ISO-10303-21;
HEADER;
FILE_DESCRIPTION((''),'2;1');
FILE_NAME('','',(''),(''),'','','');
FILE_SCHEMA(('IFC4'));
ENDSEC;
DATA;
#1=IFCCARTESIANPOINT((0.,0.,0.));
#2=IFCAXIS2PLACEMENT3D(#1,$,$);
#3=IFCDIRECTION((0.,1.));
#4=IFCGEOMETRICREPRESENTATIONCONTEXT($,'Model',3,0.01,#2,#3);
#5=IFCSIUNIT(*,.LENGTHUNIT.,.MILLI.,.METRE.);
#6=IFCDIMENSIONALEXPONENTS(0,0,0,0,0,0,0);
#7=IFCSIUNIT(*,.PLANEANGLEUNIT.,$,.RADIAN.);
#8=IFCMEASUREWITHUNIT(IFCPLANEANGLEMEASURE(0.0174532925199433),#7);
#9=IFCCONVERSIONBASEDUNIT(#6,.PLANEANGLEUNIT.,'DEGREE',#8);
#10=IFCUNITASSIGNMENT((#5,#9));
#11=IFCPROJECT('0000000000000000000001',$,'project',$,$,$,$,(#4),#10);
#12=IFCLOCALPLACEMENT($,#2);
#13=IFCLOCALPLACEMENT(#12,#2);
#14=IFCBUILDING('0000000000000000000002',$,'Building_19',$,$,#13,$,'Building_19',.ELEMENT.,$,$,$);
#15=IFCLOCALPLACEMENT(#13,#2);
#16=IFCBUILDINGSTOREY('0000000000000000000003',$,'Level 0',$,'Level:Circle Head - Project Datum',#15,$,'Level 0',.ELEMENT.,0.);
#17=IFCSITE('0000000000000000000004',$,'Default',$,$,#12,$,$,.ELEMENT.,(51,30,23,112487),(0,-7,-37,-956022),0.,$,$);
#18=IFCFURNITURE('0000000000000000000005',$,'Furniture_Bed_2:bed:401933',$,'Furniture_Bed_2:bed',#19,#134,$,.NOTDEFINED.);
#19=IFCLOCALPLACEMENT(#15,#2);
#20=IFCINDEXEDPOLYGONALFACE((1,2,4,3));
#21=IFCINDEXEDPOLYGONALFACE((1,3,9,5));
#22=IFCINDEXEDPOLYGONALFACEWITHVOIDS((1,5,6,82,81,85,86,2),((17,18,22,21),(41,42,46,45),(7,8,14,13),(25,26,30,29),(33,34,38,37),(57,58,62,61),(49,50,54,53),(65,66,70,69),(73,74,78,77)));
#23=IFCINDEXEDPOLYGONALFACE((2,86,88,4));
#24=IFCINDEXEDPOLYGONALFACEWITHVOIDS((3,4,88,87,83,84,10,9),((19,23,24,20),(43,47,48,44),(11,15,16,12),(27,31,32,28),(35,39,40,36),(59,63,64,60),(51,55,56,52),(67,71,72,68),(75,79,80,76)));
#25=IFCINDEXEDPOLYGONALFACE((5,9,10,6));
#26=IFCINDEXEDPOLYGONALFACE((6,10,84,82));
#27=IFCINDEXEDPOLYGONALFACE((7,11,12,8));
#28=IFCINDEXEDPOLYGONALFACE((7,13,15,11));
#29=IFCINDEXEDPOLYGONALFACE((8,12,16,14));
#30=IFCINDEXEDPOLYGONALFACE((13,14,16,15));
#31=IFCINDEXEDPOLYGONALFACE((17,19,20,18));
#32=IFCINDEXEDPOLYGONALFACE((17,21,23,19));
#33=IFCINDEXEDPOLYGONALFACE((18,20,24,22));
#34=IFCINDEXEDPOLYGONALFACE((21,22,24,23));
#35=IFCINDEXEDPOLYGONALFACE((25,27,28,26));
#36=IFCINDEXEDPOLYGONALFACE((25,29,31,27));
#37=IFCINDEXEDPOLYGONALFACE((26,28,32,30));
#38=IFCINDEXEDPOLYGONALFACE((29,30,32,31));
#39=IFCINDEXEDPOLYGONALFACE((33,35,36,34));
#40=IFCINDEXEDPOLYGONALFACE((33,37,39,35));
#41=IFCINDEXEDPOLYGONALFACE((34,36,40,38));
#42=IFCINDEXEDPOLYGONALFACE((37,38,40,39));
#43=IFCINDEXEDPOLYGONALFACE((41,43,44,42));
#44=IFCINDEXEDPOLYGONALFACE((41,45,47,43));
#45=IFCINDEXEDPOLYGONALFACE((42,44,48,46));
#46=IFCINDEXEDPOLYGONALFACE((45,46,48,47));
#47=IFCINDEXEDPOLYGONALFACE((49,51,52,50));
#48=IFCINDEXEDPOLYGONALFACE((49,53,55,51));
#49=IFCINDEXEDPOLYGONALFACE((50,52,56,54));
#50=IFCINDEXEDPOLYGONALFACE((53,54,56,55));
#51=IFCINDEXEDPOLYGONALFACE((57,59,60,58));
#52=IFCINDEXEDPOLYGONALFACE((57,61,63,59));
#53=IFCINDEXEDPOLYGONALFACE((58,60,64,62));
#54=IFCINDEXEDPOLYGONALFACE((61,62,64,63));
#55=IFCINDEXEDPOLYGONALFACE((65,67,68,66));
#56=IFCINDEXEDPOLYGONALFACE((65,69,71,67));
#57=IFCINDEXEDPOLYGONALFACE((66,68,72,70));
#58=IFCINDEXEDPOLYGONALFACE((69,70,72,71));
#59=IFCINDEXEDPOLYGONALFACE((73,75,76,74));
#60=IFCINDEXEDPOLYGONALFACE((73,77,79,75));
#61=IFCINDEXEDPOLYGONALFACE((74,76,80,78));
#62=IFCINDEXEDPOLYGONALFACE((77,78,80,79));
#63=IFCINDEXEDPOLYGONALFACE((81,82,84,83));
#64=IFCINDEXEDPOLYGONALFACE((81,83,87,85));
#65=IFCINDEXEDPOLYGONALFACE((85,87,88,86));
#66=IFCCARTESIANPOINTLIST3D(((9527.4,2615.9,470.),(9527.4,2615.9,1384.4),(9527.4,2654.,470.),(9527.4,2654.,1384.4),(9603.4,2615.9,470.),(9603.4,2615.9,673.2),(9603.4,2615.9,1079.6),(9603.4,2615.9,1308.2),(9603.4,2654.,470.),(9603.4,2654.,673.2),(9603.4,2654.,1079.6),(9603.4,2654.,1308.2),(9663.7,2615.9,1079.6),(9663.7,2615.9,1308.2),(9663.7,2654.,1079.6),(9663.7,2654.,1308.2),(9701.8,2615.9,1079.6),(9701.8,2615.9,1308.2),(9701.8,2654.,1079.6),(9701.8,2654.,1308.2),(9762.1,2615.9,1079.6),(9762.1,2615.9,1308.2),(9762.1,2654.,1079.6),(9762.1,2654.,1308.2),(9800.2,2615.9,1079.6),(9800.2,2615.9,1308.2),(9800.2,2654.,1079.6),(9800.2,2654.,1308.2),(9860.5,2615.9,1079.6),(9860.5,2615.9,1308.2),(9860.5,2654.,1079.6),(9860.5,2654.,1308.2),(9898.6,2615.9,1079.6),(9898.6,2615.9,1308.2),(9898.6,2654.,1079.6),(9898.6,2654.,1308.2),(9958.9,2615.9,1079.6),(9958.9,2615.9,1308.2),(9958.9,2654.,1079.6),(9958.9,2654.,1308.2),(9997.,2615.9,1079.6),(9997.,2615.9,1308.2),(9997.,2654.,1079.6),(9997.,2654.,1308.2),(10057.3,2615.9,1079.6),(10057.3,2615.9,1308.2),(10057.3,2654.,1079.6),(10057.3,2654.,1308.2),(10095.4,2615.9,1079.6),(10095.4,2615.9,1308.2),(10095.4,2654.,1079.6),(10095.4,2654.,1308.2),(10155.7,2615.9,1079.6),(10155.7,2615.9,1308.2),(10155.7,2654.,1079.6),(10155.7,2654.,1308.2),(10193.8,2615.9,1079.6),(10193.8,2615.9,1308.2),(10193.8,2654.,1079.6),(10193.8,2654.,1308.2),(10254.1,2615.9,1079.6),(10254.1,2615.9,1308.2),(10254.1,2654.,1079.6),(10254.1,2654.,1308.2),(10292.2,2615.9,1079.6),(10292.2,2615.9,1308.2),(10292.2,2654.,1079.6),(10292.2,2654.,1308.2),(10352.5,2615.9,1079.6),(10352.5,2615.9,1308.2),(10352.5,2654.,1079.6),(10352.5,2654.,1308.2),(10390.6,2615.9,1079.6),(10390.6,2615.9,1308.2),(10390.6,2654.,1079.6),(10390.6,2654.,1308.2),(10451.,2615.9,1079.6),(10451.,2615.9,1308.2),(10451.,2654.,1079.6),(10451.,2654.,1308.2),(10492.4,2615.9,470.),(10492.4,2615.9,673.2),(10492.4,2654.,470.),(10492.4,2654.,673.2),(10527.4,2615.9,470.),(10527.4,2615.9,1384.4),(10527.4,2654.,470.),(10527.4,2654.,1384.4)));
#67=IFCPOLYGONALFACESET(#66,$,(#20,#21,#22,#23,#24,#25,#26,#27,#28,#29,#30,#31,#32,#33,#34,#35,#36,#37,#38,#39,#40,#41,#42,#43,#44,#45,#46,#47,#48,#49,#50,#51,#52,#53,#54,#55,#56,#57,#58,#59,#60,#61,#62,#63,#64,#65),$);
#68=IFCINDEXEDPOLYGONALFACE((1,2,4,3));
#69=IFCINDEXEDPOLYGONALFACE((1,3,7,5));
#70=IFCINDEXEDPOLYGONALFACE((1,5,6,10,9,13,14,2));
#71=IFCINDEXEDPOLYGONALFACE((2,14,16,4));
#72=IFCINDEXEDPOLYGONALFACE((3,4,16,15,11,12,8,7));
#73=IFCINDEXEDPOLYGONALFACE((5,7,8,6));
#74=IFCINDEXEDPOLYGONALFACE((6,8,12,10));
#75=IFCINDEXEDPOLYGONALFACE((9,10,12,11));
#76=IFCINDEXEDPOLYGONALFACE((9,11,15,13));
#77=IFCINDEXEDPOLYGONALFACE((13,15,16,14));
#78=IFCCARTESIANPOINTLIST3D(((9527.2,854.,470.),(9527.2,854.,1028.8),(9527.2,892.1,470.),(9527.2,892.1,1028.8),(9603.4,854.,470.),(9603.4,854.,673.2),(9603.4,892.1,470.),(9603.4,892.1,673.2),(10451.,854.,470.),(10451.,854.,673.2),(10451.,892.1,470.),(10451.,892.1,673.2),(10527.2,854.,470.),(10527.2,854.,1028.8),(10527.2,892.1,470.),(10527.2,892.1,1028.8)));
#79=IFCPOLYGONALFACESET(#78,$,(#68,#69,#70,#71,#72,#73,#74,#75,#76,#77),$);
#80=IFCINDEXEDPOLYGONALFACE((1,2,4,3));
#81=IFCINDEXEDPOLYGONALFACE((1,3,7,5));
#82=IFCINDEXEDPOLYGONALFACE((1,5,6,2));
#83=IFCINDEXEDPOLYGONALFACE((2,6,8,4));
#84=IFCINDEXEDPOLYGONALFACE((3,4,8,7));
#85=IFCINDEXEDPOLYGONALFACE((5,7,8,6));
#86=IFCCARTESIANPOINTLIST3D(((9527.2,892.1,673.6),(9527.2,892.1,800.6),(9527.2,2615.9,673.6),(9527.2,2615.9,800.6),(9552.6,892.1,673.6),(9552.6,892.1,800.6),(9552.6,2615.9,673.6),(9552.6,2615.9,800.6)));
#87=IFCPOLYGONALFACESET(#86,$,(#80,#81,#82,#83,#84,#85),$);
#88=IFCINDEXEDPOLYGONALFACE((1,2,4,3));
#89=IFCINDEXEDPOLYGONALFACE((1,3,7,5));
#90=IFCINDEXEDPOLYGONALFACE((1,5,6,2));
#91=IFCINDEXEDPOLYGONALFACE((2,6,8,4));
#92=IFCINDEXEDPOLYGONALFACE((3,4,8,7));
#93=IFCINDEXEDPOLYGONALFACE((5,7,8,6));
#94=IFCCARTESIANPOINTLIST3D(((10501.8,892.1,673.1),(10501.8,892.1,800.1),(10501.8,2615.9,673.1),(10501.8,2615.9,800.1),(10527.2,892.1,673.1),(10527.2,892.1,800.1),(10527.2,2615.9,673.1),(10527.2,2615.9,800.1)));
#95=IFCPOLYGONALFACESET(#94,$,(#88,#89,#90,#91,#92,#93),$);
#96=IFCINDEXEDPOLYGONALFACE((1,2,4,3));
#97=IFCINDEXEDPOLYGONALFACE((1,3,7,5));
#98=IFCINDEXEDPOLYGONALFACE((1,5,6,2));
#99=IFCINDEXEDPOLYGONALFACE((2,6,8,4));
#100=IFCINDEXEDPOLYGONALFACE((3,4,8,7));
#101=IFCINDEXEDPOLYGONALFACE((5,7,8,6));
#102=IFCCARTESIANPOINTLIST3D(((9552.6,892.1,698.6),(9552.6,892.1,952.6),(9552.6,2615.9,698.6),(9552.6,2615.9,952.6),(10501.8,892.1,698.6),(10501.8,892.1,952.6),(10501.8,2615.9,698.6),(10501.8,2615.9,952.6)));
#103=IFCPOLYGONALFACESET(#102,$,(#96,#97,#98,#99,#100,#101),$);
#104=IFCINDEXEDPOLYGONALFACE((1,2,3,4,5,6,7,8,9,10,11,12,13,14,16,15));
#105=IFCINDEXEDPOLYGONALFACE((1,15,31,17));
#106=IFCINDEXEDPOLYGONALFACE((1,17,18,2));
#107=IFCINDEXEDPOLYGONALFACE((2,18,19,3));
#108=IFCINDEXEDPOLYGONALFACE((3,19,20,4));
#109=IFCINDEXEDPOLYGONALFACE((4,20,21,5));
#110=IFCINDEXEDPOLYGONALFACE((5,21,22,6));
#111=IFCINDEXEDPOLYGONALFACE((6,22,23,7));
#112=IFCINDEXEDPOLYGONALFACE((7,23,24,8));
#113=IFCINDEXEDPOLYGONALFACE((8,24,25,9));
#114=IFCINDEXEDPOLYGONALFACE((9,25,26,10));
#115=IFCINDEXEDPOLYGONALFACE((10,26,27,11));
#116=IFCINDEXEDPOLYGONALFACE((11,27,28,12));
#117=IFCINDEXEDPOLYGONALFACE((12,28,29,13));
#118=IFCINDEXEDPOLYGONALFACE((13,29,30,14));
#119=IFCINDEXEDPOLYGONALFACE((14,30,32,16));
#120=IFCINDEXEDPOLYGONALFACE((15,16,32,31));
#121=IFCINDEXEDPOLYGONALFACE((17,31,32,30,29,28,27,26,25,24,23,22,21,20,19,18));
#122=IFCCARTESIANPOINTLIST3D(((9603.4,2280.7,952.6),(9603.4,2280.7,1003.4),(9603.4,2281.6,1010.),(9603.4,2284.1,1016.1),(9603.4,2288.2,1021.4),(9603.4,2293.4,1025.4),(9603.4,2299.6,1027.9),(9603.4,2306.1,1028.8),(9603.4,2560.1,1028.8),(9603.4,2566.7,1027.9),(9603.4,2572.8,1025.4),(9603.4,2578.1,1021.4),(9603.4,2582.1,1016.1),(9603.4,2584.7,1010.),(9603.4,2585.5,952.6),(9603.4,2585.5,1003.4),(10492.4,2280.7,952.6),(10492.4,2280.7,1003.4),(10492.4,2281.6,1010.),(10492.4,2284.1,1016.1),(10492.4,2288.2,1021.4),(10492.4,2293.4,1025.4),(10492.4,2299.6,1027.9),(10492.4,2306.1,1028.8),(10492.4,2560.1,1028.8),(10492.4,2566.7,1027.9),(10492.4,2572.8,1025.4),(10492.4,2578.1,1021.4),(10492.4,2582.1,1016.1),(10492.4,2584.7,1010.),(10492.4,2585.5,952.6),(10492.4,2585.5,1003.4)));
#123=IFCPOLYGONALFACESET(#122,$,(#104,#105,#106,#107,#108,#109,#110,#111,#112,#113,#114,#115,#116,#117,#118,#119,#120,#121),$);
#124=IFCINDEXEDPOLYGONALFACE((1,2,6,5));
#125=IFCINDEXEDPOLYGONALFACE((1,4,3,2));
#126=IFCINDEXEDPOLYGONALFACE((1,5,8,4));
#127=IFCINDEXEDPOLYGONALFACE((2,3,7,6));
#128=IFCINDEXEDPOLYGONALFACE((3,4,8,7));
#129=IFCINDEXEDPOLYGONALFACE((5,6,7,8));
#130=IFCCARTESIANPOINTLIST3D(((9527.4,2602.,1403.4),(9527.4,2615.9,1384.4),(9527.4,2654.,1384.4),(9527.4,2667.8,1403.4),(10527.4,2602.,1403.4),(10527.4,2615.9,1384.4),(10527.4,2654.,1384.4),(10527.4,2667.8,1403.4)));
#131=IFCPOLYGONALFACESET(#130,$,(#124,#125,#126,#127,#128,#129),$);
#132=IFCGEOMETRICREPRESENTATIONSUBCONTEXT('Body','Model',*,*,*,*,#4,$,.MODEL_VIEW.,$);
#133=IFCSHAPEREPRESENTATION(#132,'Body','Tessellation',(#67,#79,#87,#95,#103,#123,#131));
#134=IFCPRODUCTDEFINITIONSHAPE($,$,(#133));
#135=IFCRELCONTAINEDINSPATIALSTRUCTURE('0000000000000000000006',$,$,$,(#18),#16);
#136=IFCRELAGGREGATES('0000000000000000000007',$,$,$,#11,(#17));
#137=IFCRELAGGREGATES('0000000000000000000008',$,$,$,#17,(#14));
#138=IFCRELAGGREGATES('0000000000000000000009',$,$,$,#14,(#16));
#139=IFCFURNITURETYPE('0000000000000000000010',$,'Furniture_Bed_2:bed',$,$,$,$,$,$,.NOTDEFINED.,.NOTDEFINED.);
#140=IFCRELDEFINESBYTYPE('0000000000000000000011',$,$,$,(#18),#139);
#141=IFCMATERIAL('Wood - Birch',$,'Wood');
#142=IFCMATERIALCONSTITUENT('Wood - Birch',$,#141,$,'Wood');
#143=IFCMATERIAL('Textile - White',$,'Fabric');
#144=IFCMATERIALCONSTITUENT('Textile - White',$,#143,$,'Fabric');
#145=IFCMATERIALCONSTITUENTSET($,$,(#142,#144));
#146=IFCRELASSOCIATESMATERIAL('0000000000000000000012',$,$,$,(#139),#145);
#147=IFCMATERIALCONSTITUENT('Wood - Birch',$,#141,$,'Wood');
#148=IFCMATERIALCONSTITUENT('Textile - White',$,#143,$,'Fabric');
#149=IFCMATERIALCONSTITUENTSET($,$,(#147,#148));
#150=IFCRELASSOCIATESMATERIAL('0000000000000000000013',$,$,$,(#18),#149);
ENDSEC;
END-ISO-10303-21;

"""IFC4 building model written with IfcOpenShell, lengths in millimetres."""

from ifc_helpers import new_model, entity, si_unit, converted_unit, direction, frame, origin, place, context, subcontext, project, spatial, line, arc, indexed_curve, outline, extrude, source, transform, mapped, material, constituent, constituent_set, type_object, type_shapes, element, save


model = new_model("IFC4")

# Units and contexts
model_context = context("Model", 3, precision=0.01, world=origin(), true_north=direction((0.0, 1.0)))
body_context = subcontext(model_context, "Body", "Model", "MODEL_VIEW")
ifc_project = project(units=[si_unit("LENGTHUNIT", "METRE", prefix="MILLI"), converted_unit("PLANEANGLEUNIT", "DEGREE", entity("IfcPlaneAngleMeasure", 0.0174532925199433), si_unit("PLANEANGLEUNIT", "RADIAN"), dimensions=[0, 0, 0, 0, 0, 0, 0])], contexts=[model_context])

# Site, building, storey
site_placement = place(None, origin())
site = spatial("IfcSite", under=ifc_project, at=site_placement, Name="Default", CompositionType="ELEMENT", RefLatitude=(51, 30, 23, 112487), RefLongitude=(0, -7, -37, -956022), RefElevation=0.0)
building_placement = place(site_placement, origin())
building = spatial("IfcBuilding", under=site, at=building_placement, Name="Building_19", LongName="Building_19", CompositionType="ELEMENT")
storey_placement = place(building_placement, origin())
storey = spatial("IfcBuildingStorey", under=building, at=storey_placement, Name="Level 0", ObjectType="Level:Circle Head - Project Datum", LongName="Level 0", CompositionType="ELEMENT", Elevation=0.0)

# Furniture
ifc_material_1 = material(Name="Wood - Birch", Category="Wood")
ifc_material_2 = material(Name="Textile - White", Category="Fabric")
ifc_constituent_1 = constituent(ifc_material_1, Name="Wood - Birch", Category="Wood")
ifc_constituent_2 = constituent(ifc_material_2, Name="Textile - White", Category="Fabric")
ifc_constituent_set_1 = constituent_set(constituents=[ifc_constituent_1, ifc_constituent_2])
furniture_type = type_object("IfcFurnitureType", Name="Furniture_Bed_2:bed", AssemblyPlace="NOTDEFINED", PredefinedType="NOTDEFINED", material=ifc_constituent_set_1)
shared_shape_1 = source(origin(), body_context, "Body", "SweptSolid", [
    extrude(outline(indexed_curve([(-635.0, -489.8), (279.4, -489.8), (279.4, -454.7), (76.2, -454.7), (76.2, 434.3), (279.4, 434.3), (279.4, 510.3), (-635.0, 510.3), (-635.0, -489.8)], self_intersect=False), holes=[indexed_curve([(-558.8, 374.0), (-558.8, 434.3), (-330.2, 434.3), (-330.2, 374.0), (-558.8, 374.0)], self_intersect=False), indexed_curve([(-558.8, 275.5), (-558.8, 335.9), (-330.2, 335.9), (-330.2, 275.5), (-558.8, 275.5)], self_intersect=False), indexed_curve([(-558.8, 177.1), (-558.8, 237.4), (-330.2, 237.4), (-330.2, 177.1), (-558.8, 177.1)], self_intersect=False), indexed_curve([(-558.8, 78.7), (-558.8, 139.0), (-330.2, 139.0), (-330.2, 78.7), (-558.8, 78.7)], self_intersect=False), indexed_curve([(-558.8, -118.1), (-558.8, -57.8), (-330.2, -57.8), (-330.2, -118.1), (-558.8, -118.1)], self_intersect=False), indexed_curve([(-558.8, -216.5), (-558.8, -156.2), (-330.2, -156.2), (-330.2, -216.5), (-558.8, -216.5)], self_intersect=False), indexed_curve([(-558.8, -314.9), (-558.8, -254.6), (-330.2, -254.6), (-330.2, -314.9), (-558.8, -314.9)], self_intersect=False), indexed_curve([(-558.8, -413.3), (-558.8, -353.0), (-330.2, -353.0), (-330.2, -413.3), (-558.8, -413.3)], self_intersect=False), indexed_curve([(-558.8, -19.7), (-558.8, 40.6), (-330.2, 40.6), (-330.2, -19.7), (-558.8, -19.7)], self_intersect=False)]), frame((-8.6, -38.1, 279.4), z_axis=(0.0, 1.0, 0.0), x_axis=(0.0, 0.0, -1.0)), (0.0, 0.0, 1.0), 38.1),
    extrude(outline(indexed_curve([(423.8, -190.5), (500.0, -190.5), (500.0, 368.3), (-500.0, 368.3), (-500.0, -190.5), (-423.8, -190.5), (-423.8, 12.7), (423.8, 12.7), (423.8, -190.5)], self_intersect=False)), frame((-19.1, -1800.0, 190.5), z_axis=(0.0, 1.0, 0.0), x_axis=(-1.0, 0.0, 0.0)), (0.0, 0.0, 1.0), 38.1),
    extrude(outline(indexed_curve([(-12.7, -861.9), (12.7, -861.9), (12.7, 861.9), (-12.7, 861.9), (-12.7, -861.9)], self_intersect=False)), frame((-506.4, -900.0, 203.6)), (0.0, 0.0, 1.0), 127.0),
    extrude(outline(indexed_curve([(-12.7, -861.9), (12.7, -861.9), (12.7, 861.9), (-12.7, 861.9), (-12.7, -861.9)], self_intersect=False)), frame((468.2, -900.0, 203.1)), (0.0, 0.0, 1.0), 127.0),
    extrude(outline(indexed_curve([(-474.6, -861.9), (474.6, -861.9), (474.6, 861.9), (-474.6, 861.9), (-474.6, -861.9)], self_intersect=False)), frame((-19.0, -900.0, 228.6), z_axis=(0.0, 0.0, 1.0), x_axis=(-1.0, 0.0, 0.0)), (0.0, 0.0, 1.0), 254.0),
    extrude(outline(indexed_curve([(-152.4, -42.3), (152.4, -42.3), (152.4, 8.5), (145.0, 26.4), (127.0, 33.9), (-127.0, 33.9), (-145.0, 26.4), (-152.4, 8.5)], segments=[line(1, 2, 3), arc(3, 4, 5), line(5, 6), arc(6, 7, 8), line(8, 1)], self_intersect=False)), frame((-442.9, -220.8, 524.9), z_axis=(1.0, 0.0, 0.0), x_axis=(0.0, 1.0, 0.0)), (0.0, 0.0, 1.0), 889.0),
    extrude(outline(indexed_curve([(-19.1, -9.5), (19.0, -9.5), (32.9, 9.5), (-32.9, 9.5), (-19.1, -9.5)], self_intersect=False)), frame((-518.8, -19.0, 923.9), z_axis=(1.0, 0.0, 0.0), x_axis=(0.0, 1.0, 0.0)), (0.0, 0.0, 1.0), 1000.1),
])
type_shapes(furniture_type, [shared_shape_1])
ifc_constituent_3 = constituent(ifc_material_1, Name="Wood - Birch", Category="Wood")
ifc_constituent_4 = constituent(ifc_material_2, Name="Textile - White", Category="Fabric")
ifc_constituent_set_2 = constituent_set(constituents=[ifc_constituent_3, ifc_constituent_4])
furniture_1_placement = place(storey_placement, frame((10046.2, 2654.0, 470.0)))
element("IfcFurniture", 1, at=furniture_1_placement, inside=storey, type_object=furniture_type, material=ifc_constituent_set_2, Name="Furniture_Bed_2:bed:401933", ObjectType="Furniture_Bed_2:bed", PredefinedType="NOTDEFINED", context=body_context, shape_type="MappedRepresentation", body=[
    mapped(shared_shape_1, transform((0.0, 0.0, 0.0), scale=1.0)),
])

save(model, "model.ifc")
